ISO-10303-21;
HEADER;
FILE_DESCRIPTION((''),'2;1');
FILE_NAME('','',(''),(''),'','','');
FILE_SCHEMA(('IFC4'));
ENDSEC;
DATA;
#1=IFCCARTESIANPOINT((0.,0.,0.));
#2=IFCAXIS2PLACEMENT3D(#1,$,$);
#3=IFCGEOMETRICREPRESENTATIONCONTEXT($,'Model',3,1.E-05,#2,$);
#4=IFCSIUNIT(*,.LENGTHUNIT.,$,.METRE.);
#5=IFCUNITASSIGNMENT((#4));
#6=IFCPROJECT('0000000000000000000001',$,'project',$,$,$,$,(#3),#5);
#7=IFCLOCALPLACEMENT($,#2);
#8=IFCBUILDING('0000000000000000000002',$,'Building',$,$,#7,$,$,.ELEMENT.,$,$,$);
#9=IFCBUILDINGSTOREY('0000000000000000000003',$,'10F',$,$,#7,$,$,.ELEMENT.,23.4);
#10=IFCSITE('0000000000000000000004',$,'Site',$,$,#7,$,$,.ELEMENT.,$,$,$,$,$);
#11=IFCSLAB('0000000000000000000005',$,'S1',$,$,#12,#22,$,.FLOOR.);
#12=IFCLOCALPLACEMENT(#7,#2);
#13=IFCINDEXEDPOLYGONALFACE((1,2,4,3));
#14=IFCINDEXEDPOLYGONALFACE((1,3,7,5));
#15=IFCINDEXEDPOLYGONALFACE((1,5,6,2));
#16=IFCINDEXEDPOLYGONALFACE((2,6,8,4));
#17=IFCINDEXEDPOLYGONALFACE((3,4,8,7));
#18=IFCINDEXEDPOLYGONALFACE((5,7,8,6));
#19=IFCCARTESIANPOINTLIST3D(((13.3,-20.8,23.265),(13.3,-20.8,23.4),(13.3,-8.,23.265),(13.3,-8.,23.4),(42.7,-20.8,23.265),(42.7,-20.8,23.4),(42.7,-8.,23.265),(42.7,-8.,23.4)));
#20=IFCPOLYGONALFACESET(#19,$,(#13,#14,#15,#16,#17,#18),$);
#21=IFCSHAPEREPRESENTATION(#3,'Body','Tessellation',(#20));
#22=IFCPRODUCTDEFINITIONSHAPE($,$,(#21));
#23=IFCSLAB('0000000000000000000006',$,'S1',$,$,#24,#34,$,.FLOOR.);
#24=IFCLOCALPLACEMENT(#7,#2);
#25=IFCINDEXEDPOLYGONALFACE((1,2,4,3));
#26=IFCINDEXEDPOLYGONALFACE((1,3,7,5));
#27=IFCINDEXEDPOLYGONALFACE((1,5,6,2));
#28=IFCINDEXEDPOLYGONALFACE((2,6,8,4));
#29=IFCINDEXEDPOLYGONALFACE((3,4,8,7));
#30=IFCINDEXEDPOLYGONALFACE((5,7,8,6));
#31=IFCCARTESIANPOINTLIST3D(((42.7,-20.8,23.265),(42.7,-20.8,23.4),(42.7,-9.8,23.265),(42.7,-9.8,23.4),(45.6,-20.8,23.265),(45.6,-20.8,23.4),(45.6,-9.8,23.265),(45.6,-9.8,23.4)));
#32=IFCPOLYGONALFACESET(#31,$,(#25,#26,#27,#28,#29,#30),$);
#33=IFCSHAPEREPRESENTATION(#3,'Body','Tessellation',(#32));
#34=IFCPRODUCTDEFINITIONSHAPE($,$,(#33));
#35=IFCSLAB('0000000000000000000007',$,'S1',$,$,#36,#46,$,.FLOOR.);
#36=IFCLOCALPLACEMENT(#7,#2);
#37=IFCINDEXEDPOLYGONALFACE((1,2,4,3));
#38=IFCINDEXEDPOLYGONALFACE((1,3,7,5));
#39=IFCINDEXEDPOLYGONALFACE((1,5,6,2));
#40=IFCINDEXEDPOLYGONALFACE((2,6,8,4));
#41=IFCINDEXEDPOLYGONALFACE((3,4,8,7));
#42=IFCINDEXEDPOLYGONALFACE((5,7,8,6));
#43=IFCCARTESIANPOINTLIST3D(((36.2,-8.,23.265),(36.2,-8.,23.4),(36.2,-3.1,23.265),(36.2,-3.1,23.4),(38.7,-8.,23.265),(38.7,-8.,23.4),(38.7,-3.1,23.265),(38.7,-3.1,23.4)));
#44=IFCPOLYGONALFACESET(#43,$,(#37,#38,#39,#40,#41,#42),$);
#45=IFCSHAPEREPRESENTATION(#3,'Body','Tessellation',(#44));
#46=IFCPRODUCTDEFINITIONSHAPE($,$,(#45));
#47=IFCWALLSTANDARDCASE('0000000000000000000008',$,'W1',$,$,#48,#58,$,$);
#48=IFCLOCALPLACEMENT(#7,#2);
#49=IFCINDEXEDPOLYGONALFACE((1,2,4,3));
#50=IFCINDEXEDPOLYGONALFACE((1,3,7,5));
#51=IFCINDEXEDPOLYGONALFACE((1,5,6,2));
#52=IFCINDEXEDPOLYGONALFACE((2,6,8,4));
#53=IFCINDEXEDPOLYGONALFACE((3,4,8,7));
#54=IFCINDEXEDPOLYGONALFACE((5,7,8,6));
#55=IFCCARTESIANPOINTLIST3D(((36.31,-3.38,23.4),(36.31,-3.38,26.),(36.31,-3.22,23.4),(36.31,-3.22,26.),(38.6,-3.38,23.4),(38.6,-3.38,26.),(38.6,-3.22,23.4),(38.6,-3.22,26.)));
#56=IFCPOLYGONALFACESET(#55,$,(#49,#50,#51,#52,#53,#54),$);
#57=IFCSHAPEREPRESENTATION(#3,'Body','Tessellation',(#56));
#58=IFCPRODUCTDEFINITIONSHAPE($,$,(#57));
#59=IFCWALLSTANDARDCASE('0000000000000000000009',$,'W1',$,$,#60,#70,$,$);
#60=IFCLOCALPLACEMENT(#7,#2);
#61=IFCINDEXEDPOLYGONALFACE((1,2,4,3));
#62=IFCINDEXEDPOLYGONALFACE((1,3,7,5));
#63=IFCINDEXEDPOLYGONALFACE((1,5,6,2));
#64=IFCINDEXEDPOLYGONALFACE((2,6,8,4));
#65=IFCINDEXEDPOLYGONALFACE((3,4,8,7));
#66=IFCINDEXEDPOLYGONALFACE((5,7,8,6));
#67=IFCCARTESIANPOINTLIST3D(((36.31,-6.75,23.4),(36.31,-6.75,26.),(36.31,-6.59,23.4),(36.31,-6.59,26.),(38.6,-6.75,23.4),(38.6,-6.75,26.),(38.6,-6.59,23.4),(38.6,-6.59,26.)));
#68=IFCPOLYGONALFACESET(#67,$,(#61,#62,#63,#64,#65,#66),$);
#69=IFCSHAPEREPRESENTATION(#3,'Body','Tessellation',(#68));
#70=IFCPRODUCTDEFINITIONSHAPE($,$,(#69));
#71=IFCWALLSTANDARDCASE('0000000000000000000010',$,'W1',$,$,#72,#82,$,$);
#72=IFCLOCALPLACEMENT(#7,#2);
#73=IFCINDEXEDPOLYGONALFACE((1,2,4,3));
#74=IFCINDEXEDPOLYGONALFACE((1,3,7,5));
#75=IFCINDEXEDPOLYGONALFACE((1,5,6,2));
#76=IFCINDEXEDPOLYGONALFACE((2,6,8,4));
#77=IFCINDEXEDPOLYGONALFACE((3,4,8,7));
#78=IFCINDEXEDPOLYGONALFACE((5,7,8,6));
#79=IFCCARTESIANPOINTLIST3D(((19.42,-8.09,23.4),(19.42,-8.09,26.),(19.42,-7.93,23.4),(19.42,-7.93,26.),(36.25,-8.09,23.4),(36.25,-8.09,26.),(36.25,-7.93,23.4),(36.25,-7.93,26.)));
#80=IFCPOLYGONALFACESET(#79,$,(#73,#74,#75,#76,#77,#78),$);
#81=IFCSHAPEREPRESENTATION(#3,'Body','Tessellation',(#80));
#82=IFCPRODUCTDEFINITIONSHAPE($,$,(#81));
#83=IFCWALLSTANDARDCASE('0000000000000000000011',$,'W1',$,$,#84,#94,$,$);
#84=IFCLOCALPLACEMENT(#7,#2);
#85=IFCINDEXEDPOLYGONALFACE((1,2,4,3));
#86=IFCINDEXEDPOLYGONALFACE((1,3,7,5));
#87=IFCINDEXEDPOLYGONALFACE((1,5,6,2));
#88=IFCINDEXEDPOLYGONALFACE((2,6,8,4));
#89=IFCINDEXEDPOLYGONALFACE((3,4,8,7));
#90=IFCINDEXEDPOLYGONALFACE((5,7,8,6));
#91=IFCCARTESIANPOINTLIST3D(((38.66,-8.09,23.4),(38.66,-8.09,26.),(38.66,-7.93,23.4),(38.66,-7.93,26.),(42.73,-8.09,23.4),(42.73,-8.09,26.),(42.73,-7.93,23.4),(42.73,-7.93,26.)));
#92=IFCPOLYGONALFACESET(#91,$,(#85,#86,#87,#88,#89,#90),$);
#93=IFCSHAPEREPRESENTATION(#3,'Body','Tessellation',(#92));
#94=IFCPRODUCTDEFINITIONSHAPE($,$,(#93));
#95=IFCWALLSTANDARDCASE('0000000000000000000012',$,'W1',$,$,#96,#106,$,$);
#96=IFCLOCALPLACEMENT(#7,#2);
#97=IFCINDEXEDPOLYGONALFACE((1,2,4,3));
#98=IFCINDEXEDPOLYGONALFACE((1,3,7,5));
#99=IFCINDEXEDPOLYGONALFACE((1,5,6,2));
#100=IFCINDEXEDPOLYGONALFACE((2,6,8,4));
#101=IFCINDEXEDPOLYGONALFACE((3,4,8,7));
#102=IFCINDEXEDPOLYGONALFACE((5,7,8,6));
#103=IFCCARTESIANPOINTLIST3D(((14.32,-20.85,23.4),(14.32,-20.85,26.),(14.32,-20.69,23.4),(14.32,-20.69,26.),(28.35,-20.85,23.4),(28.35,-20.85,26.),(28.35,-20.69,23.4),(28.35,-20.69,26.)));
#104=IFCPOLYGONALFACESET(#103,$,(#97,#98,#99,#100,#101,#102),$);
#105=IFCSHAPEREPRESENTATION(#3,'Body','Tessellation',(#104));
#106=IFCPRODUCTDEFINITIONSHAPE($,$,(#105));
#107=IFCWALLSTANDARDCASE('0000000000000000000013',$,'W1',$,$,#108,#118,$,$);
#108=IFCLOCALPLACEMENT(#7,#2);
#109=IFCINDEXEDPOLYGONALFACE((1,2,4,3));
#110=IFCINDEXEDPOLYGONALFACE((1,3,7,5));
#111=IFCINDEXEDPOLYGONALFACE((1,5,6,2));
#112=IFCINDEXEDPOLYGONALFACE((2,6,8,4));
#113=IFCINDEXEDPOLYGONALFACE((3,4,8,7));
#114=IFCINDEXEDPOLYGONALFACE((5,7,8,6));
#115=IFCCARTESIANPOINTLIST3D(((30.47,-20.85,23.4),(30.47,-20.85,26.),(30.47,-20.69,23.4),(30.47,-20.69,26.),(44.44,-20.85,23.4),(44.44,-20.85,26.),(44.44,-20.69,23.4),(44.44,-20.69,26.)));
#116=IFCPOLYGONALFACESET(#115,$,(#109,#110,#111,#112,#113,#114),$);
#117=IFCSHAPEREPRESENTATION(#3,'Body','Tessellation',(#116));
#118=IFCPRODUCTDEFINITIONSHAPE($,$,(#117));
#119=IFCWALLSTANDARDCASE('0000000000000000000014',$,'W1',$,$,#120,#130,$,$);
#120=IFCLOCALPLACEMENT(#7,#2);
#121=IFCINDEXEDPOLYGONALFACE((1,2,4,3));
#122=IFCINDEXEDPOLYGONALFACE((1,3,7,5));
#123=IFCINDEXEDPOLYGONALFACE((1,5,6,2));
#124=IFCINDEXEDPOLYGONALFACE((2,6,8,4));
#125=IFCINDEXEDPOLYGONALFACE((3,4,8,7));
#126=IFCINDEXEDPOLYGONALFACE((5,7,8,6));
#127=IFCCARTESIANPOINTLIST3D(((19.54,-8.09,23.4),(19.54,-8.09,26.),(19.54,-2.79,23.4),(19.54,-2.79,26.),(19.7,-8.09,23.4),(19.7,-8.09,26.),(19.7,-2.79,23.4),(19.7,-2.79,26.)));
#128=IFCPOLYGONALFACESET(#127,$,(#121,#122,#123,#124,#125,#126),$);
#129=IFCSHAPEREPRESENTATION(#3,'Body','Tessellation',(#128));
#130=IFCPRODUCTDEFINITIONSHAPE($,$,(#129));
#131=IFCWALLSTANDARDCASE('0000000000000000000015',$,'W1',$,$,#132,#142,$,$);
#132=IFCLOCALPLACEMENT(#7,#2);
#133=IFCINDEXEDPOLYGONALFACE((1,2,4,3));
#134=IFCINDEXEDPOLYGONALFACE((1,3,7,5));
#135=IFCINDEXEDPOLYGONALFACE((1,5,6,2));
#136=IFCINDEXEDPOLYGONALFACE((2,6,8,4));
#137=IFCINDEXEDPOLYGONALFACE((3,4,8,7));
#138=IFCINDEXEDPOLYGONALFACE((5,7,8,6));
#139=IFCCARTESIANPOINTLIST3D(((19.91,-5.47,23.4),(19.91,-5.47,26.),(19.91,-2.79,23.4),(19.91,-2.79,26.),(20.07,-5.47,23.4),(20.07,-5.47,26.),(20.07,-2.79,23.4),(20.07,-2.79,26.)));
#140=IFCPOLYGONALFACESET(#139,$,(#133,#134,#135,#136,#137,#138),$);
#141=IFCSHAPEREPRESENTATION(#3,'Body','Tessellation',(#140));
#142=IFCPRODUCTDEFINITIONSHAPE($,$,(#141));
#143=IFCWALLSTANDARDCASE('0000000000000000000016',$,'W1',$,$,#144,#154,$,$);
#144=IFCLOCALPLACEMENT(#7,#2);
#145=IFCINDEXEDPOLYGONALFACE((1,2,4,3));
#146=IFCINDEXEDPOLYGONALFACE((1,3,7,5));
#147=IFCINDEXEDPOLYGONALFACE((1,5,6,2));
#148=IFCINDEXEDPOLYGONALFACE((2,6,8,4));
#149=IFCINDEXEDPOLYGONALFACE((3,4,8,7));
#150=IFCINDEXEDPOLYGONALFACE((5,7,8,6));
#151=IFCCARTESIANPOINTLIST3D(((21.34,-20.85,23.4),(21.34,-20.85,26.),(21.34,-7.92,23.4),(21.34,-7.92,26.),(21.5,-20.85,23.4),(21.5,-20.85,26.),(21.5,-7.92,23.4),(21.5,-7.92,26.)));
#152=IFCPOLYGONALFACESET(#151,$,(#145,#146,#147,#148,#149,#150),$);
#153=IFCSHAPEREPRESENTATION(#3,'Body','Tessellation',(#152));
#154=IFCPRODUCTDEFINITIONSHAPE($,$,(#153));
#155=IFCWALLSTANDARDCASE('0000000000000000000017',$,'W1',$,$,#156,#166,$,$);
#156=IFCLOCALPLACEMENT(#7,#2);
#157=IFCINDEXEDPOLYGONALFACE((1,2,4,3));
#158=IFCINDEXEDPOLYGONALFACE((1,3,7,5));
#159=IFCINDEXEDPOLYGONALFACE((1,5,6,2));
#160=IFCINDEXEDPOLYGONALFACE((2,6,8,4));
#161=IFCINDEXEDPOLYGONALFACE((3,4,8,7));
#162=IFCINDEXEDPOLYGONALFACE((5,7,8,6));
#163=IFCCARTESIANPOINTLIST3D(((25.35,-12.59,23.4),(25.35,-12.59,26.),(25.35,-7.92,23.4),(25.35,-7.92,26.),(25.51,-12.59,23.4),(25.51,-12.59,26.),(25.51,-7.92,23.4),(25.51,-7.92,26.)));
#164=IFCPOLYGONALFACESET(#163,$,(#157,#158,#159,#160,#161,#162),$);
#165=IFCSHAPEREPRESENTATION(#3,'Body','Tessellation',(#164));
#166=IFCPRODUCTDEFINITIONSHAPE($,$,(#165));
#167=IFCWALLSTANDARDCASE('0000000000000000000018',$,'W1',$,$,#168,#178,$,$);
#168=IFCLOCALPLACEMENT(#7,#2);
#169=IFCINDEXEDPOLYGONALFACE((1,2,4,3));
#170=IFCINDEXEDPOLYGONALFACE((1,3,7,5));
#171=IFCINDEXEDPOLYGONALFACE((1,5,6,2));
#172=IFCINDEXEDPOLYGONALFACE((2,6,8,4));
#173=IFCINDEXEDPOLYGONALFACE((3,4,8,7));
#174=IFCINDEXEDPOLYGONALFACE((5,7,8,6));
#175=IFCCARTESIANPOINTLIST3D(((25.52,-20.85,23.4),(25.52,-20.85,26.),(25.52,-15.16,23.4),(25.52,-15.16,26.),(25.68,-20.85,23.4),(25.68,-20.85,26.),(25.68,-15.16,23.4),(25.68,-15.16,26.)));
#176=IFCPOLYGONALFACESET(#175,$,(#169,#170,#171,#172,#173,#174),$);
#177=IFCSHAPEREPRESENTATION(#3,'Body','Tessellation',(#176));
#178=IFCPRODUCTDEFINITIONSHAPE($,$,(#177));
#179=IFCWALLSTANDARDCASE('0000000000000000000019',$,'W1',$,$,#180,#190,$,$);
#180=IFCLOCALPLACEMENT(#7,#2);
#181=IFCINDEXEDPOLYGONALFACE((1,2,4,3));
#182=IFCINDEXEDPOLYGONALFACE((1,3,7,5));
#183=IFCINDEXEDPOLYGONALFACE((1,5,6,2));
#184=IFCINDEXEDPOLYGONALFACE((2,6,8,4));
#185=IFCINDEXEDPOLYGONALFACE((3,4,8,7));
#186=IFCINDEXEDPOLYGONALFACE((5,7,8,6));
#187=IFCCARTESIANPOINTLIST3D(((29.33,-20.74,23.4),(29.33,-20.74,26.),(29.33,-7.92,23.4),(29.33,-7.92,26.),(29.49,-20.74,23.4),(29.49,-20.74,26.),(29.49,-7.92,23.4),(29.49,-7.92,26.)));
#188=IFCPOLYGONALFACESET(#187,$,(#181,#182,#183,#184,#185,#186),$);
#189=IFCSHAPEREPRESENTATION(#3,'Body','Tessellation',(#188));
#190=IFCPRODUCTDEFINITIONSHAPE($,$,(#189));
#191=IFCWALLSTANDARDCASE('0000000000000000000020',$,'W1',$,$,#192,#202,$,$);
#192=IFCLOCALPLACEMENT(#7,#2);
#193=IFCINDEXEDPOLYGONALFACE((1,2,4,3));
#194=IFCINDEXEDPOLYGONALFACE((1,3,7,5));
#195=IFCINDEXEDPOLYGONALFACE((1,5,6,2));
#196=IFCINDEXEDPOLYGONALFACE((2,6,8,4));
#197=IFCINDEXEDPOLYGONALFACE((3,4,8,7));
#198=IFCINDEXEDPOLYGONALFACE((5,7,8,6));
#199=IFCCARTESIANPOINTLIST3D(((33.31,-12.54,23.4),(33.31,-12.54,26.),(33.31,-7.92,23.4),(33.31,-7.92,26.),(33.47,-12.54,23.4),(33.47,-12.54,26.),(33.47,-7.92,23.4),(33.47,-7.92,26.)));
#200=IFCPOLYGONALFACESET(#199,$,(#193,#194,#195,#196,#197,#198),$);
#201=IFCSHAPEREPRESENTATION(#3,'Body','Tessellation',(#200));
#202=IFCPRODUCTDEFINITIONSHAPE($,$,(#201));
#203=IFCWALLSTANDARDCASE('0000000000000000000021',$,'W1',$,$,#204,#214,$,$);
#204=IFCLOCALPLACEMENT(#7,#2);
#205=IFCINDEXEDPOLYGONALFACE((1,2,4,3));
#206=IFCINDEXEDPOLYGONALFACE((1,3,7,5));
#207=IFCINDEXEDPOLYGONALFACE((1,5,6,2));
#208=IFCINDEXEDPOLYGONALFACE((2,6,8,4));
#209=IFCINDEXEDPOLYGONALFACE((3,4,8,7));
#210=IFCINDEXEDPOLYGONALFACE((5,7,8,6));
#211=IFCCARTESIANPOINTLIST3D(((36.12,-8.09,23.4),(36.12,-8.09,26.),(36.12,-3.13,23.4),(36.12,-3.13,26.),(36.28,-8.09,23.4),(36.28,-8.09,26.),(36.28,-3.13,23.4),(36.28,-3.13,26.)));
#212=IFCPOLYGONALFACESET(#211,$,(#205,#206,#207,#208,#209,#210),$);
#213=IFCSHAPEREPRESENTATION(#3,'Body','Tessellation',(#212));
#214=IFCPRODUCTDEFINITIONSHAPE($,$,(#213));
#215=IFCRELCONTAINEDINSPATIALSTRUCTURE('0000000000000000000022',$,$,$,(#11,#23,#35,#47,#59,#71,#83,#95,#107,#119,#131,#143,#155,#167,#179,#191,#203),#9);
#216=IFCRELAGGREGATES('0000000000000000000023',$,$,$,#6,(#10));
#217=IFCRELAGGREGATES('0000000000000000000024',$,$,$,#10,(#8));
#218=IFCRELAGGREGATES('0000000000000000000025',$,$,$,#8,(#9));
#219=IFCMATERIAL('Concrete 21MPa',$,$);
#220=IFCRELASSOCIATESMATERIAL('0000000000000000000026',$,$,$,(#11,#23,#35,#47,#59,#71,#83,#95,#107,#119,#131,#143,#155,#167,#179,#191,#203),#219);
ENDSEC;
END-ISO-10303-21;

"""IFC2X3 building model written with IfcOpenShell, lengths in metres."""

from ifc_helpers import new_model, si_unit, frame, origin, origin_2d, place, context, project, spatial, rectangle, extrude, material, element, save


model = new_model("IFC2X3")

# Units and contexts
model_context = context("Model", 3, precision=1e-05, world=origin())
ifc_project = project(units=[si_unit("LENGTHUNIT", "METRE")], contexts=[model_context])

# Site, building, storey
placement = place(None, origin())
site = spatial("IfcSite", under=ifc_project, at=placement, Name="Site", CompositionType="ELEMENT")
building = spatial("IfcBuilding", under=site, at=placement, Name="Building", CompositionType="ELEMENT")
storey = spatial("IfcBuildingStorey", under=building, at=placement, Name="10F", CompositionType="ELEMENT", Elevation=23.4)

# Slabs
ifc_material_1 = material(Name="Concrete 21MPa")
slab_1_placement = place(None, frame((28.0, -14.4, 23.265)))
element("IfcSlab", 1, at=slab_1_placement, inside=storey, material=ifc_material_1, Name="S1", PredefinedType="FLOOR", context=model_context, shape_type="SweptSolid", body=[
    extrude(rectangle(XDim=29.4, YDim=12.8, at=origin_2d()), origin(), (0.0, 0.0, 1.0), 0.135),
])
slab_2_placement = place(None, frame((44.15, -15.3, 23.265)))
element("IfcSlab", 2, at=slab_2_placement, inside=storey, material=ifc_material_1, Name="S1", PredefinedType="FLOOR", context=model_context, shape_type="SweptSolid", body=[
    extrude(rectangle(XDim=2.9, YDim=11.0, at=origin_2d()), origin(), (0.0, 0.0, 1.0), 0.135),
])
slab_3_placement = place(None, frame((37.45, -5.55, 23.265)))
element("IfcSlab", 3, at=slab_3_placement, inside=storey, material=ifc_material_1, Name="S1", PredefinedType="FLOOR", context=model_context, shape_type="SweptSolid", body=[
    extrude(rectangle(XDim=2.5, YDim=4.9, at=origin_2d()), origin(), (0.0, 0.0, 1.0), 0.135),
])

# Walls
for number, where, name in (
    (4, (37.455, -3.3, 23.4), "W1"),
    (5, (37.455, -6.67, 23.4), "W1"),
):
    element("IfcWallStandardCase", number, at=place(None, frame(where)), inside=storey, material=ifc_material_1, Name=name, context=model_context, shape_type="SweptSolid", body=[
        extrude(rectangle(XDim=2.29, YDim=0.16, at=origin_2d()), origin(), (0.0, 0.0, 1.0), 2.6),
    ])
wall_1_placement = place(None, frame((27.835, -8.01, 23.4)))
element("IfcWallStandardCase", 6, at=wall_1_placement, inside=storey, material=ifc_material_1, Name="W1", context=model_context, shape_type="SweptSolid", body=[
    extrude(rectangle(XDim=16.83, YDim=0.16, at=origin_2d()), origin(), (0.0, 0.0, 1.0), 2.6),
])
wall_2_placement = place(None, frame((40.695, -8.01, 23.4)))
element("IfcWallStandardCase", 7, at=wall_2_placement, inside=storey, material=ifc_material_1, Name="W1", context=model_context, shape_type="SweptSolid", body=[
    extrude(rectangle(XDim=4.07, YDim=0.16, at=origin_2d()), origin(), (0.0, 0.0, 1.0), 2.6),
])
wall_3_placement = place(None, frame((21.335, -20.77, 23.4)))
element("IfcWallStandardCase", 8, at=wall_3_placement, inside=storey, material=ifc_material_1, Name="W1", context=model_context, shape_type="SweptSolid", body=[
    extrude(rectangle(XDim=14.03, YDim=0.16, at=origin_2d()), origin(), (0.0, 0.0, 1.0), 2.6),
])
wall_4_placement = place(None, frame((37.455, -20.77, 23.4)))
element("IfcWallStandardCase", 9, at=wall_4_placement, inside=storey, material=ifc_material_1, Name="W1", context=model_context, shape_type="SweptSolid", body=[
    extrude(rectangle(XDim=13.97, YDim=0.16, at=origin_2d()), origin(), (0.0, 0.0, 1.0), 2.6),
])
wall_5_placement = place(None, frame((19.62, -5.44, 23.4)))
element("IfcWallStandardCase", 10, at=wall_5_placement, inside=storey, material=ifc_material_1, Name="W1", context=model_context, shape_type="SweptSolid", body=[
    extrude(rectangle(XDim=0.16, YDim=5.3, at=origin_2d()), origin(), (0.0, 0.0, 1.0), 2.6),
])
wall_6_placement = place(None, frame((19.99, -4.13, 23.4)))
element("IfcWallStandardCase", 11, at=wall_6_placement, inside=storey, material=ifc_material_1, Name="W1", context=model_context, shape_type="SweptSolid", body=[
    extrude(rectangle(XDim=0.16, YDim=2.68, at=origin_2d()), origin(), (0.0, 0.0, 1.0), 2.6),
])
wall_7_placement = place(None, frame((21.42, -14.385, 23.4)))
element("IfcWallStandardCase", 12, at=wall_7_placement, inside=storey, material=ifc_material_1, Name="W1", context=model_context, shape_type="SweptSolid", body=[
    extrude(rectangle(XDim=0.16, YDim=12.93, at=origin_2d()), origin(), (0.0, 0.0, 1.0), 2.6),
])
wall_8_placement = place(None, frame((25.43, -10.255, 23.4)))
element("IfcWallStandardCase", 13, at=wall_8_placement, inside=storey, material=ifc_material_1, Name="W1", context=model_context, shape_type="SweptSolid", body=[
    extrude(rectangle(XDim=0.16, YDim=4.67, at=origin_2d()), origin(), (0.0, 0.0, 1.0), 2.6),
])
wall_9_placement = place(None, frame((25.6, -18.005, 23.4)))
element("IfcWallStandardCase", 14, at=wall_9_placement, inside=storey, material=ifc_material_1, Name="W1", context=model_context, shape_type="SweptSolid", body=[
    extrude(rectangle(XDim=0.16, YDim=5.69, at=origin_2d()), origin(), (0.0, 0.0, 1.0), 2.6),
])
wall_10_placement = place(None, frame((29.41, -14.33, 23.4)))
element("IfcWallStandardCase", 15, at=wall_10_placement, inside=storey, material=ifc_material_1, Name="W1", context=model_context, shape_type="SweptSolid", body=[
    extrude(rectangle(XDim=0.16, YDim=12.82, at=origin_2d()), origin(), (0.0, 0.0, 1.0), 2.6),
])
wall_11_placement = place(None, frame((33.39, -10.23, 23.4)))
element("IfcWallStandardCase", 16, at=wall_11_placement, inside=storey, material=ifc_material_1, Name="W1", context=model_context, shape_type="SweptSolid", body=[
    extrude(rectangle(XDim=0.16, YDim=4.62, at=origin_2d()), origin(), (0.0, 0.0, 1.0), 2.6),
])
wall_12_placement = place(None, frame((36.2, -5.61, 23.4)))
element("IfcWallStandardCase", 17, at=wall_12_placement, inside=storey, material=ifc_material_1, Name="W1", context=model_context, shape_type="SweptSolid", body=[
    extrude(rectangle(XDim=0.16, YDim=4.96, at=origin_2d()), origin(), (0.0, 0.0, 1.0), 2.6),
])

save(model, "model.ifc")
